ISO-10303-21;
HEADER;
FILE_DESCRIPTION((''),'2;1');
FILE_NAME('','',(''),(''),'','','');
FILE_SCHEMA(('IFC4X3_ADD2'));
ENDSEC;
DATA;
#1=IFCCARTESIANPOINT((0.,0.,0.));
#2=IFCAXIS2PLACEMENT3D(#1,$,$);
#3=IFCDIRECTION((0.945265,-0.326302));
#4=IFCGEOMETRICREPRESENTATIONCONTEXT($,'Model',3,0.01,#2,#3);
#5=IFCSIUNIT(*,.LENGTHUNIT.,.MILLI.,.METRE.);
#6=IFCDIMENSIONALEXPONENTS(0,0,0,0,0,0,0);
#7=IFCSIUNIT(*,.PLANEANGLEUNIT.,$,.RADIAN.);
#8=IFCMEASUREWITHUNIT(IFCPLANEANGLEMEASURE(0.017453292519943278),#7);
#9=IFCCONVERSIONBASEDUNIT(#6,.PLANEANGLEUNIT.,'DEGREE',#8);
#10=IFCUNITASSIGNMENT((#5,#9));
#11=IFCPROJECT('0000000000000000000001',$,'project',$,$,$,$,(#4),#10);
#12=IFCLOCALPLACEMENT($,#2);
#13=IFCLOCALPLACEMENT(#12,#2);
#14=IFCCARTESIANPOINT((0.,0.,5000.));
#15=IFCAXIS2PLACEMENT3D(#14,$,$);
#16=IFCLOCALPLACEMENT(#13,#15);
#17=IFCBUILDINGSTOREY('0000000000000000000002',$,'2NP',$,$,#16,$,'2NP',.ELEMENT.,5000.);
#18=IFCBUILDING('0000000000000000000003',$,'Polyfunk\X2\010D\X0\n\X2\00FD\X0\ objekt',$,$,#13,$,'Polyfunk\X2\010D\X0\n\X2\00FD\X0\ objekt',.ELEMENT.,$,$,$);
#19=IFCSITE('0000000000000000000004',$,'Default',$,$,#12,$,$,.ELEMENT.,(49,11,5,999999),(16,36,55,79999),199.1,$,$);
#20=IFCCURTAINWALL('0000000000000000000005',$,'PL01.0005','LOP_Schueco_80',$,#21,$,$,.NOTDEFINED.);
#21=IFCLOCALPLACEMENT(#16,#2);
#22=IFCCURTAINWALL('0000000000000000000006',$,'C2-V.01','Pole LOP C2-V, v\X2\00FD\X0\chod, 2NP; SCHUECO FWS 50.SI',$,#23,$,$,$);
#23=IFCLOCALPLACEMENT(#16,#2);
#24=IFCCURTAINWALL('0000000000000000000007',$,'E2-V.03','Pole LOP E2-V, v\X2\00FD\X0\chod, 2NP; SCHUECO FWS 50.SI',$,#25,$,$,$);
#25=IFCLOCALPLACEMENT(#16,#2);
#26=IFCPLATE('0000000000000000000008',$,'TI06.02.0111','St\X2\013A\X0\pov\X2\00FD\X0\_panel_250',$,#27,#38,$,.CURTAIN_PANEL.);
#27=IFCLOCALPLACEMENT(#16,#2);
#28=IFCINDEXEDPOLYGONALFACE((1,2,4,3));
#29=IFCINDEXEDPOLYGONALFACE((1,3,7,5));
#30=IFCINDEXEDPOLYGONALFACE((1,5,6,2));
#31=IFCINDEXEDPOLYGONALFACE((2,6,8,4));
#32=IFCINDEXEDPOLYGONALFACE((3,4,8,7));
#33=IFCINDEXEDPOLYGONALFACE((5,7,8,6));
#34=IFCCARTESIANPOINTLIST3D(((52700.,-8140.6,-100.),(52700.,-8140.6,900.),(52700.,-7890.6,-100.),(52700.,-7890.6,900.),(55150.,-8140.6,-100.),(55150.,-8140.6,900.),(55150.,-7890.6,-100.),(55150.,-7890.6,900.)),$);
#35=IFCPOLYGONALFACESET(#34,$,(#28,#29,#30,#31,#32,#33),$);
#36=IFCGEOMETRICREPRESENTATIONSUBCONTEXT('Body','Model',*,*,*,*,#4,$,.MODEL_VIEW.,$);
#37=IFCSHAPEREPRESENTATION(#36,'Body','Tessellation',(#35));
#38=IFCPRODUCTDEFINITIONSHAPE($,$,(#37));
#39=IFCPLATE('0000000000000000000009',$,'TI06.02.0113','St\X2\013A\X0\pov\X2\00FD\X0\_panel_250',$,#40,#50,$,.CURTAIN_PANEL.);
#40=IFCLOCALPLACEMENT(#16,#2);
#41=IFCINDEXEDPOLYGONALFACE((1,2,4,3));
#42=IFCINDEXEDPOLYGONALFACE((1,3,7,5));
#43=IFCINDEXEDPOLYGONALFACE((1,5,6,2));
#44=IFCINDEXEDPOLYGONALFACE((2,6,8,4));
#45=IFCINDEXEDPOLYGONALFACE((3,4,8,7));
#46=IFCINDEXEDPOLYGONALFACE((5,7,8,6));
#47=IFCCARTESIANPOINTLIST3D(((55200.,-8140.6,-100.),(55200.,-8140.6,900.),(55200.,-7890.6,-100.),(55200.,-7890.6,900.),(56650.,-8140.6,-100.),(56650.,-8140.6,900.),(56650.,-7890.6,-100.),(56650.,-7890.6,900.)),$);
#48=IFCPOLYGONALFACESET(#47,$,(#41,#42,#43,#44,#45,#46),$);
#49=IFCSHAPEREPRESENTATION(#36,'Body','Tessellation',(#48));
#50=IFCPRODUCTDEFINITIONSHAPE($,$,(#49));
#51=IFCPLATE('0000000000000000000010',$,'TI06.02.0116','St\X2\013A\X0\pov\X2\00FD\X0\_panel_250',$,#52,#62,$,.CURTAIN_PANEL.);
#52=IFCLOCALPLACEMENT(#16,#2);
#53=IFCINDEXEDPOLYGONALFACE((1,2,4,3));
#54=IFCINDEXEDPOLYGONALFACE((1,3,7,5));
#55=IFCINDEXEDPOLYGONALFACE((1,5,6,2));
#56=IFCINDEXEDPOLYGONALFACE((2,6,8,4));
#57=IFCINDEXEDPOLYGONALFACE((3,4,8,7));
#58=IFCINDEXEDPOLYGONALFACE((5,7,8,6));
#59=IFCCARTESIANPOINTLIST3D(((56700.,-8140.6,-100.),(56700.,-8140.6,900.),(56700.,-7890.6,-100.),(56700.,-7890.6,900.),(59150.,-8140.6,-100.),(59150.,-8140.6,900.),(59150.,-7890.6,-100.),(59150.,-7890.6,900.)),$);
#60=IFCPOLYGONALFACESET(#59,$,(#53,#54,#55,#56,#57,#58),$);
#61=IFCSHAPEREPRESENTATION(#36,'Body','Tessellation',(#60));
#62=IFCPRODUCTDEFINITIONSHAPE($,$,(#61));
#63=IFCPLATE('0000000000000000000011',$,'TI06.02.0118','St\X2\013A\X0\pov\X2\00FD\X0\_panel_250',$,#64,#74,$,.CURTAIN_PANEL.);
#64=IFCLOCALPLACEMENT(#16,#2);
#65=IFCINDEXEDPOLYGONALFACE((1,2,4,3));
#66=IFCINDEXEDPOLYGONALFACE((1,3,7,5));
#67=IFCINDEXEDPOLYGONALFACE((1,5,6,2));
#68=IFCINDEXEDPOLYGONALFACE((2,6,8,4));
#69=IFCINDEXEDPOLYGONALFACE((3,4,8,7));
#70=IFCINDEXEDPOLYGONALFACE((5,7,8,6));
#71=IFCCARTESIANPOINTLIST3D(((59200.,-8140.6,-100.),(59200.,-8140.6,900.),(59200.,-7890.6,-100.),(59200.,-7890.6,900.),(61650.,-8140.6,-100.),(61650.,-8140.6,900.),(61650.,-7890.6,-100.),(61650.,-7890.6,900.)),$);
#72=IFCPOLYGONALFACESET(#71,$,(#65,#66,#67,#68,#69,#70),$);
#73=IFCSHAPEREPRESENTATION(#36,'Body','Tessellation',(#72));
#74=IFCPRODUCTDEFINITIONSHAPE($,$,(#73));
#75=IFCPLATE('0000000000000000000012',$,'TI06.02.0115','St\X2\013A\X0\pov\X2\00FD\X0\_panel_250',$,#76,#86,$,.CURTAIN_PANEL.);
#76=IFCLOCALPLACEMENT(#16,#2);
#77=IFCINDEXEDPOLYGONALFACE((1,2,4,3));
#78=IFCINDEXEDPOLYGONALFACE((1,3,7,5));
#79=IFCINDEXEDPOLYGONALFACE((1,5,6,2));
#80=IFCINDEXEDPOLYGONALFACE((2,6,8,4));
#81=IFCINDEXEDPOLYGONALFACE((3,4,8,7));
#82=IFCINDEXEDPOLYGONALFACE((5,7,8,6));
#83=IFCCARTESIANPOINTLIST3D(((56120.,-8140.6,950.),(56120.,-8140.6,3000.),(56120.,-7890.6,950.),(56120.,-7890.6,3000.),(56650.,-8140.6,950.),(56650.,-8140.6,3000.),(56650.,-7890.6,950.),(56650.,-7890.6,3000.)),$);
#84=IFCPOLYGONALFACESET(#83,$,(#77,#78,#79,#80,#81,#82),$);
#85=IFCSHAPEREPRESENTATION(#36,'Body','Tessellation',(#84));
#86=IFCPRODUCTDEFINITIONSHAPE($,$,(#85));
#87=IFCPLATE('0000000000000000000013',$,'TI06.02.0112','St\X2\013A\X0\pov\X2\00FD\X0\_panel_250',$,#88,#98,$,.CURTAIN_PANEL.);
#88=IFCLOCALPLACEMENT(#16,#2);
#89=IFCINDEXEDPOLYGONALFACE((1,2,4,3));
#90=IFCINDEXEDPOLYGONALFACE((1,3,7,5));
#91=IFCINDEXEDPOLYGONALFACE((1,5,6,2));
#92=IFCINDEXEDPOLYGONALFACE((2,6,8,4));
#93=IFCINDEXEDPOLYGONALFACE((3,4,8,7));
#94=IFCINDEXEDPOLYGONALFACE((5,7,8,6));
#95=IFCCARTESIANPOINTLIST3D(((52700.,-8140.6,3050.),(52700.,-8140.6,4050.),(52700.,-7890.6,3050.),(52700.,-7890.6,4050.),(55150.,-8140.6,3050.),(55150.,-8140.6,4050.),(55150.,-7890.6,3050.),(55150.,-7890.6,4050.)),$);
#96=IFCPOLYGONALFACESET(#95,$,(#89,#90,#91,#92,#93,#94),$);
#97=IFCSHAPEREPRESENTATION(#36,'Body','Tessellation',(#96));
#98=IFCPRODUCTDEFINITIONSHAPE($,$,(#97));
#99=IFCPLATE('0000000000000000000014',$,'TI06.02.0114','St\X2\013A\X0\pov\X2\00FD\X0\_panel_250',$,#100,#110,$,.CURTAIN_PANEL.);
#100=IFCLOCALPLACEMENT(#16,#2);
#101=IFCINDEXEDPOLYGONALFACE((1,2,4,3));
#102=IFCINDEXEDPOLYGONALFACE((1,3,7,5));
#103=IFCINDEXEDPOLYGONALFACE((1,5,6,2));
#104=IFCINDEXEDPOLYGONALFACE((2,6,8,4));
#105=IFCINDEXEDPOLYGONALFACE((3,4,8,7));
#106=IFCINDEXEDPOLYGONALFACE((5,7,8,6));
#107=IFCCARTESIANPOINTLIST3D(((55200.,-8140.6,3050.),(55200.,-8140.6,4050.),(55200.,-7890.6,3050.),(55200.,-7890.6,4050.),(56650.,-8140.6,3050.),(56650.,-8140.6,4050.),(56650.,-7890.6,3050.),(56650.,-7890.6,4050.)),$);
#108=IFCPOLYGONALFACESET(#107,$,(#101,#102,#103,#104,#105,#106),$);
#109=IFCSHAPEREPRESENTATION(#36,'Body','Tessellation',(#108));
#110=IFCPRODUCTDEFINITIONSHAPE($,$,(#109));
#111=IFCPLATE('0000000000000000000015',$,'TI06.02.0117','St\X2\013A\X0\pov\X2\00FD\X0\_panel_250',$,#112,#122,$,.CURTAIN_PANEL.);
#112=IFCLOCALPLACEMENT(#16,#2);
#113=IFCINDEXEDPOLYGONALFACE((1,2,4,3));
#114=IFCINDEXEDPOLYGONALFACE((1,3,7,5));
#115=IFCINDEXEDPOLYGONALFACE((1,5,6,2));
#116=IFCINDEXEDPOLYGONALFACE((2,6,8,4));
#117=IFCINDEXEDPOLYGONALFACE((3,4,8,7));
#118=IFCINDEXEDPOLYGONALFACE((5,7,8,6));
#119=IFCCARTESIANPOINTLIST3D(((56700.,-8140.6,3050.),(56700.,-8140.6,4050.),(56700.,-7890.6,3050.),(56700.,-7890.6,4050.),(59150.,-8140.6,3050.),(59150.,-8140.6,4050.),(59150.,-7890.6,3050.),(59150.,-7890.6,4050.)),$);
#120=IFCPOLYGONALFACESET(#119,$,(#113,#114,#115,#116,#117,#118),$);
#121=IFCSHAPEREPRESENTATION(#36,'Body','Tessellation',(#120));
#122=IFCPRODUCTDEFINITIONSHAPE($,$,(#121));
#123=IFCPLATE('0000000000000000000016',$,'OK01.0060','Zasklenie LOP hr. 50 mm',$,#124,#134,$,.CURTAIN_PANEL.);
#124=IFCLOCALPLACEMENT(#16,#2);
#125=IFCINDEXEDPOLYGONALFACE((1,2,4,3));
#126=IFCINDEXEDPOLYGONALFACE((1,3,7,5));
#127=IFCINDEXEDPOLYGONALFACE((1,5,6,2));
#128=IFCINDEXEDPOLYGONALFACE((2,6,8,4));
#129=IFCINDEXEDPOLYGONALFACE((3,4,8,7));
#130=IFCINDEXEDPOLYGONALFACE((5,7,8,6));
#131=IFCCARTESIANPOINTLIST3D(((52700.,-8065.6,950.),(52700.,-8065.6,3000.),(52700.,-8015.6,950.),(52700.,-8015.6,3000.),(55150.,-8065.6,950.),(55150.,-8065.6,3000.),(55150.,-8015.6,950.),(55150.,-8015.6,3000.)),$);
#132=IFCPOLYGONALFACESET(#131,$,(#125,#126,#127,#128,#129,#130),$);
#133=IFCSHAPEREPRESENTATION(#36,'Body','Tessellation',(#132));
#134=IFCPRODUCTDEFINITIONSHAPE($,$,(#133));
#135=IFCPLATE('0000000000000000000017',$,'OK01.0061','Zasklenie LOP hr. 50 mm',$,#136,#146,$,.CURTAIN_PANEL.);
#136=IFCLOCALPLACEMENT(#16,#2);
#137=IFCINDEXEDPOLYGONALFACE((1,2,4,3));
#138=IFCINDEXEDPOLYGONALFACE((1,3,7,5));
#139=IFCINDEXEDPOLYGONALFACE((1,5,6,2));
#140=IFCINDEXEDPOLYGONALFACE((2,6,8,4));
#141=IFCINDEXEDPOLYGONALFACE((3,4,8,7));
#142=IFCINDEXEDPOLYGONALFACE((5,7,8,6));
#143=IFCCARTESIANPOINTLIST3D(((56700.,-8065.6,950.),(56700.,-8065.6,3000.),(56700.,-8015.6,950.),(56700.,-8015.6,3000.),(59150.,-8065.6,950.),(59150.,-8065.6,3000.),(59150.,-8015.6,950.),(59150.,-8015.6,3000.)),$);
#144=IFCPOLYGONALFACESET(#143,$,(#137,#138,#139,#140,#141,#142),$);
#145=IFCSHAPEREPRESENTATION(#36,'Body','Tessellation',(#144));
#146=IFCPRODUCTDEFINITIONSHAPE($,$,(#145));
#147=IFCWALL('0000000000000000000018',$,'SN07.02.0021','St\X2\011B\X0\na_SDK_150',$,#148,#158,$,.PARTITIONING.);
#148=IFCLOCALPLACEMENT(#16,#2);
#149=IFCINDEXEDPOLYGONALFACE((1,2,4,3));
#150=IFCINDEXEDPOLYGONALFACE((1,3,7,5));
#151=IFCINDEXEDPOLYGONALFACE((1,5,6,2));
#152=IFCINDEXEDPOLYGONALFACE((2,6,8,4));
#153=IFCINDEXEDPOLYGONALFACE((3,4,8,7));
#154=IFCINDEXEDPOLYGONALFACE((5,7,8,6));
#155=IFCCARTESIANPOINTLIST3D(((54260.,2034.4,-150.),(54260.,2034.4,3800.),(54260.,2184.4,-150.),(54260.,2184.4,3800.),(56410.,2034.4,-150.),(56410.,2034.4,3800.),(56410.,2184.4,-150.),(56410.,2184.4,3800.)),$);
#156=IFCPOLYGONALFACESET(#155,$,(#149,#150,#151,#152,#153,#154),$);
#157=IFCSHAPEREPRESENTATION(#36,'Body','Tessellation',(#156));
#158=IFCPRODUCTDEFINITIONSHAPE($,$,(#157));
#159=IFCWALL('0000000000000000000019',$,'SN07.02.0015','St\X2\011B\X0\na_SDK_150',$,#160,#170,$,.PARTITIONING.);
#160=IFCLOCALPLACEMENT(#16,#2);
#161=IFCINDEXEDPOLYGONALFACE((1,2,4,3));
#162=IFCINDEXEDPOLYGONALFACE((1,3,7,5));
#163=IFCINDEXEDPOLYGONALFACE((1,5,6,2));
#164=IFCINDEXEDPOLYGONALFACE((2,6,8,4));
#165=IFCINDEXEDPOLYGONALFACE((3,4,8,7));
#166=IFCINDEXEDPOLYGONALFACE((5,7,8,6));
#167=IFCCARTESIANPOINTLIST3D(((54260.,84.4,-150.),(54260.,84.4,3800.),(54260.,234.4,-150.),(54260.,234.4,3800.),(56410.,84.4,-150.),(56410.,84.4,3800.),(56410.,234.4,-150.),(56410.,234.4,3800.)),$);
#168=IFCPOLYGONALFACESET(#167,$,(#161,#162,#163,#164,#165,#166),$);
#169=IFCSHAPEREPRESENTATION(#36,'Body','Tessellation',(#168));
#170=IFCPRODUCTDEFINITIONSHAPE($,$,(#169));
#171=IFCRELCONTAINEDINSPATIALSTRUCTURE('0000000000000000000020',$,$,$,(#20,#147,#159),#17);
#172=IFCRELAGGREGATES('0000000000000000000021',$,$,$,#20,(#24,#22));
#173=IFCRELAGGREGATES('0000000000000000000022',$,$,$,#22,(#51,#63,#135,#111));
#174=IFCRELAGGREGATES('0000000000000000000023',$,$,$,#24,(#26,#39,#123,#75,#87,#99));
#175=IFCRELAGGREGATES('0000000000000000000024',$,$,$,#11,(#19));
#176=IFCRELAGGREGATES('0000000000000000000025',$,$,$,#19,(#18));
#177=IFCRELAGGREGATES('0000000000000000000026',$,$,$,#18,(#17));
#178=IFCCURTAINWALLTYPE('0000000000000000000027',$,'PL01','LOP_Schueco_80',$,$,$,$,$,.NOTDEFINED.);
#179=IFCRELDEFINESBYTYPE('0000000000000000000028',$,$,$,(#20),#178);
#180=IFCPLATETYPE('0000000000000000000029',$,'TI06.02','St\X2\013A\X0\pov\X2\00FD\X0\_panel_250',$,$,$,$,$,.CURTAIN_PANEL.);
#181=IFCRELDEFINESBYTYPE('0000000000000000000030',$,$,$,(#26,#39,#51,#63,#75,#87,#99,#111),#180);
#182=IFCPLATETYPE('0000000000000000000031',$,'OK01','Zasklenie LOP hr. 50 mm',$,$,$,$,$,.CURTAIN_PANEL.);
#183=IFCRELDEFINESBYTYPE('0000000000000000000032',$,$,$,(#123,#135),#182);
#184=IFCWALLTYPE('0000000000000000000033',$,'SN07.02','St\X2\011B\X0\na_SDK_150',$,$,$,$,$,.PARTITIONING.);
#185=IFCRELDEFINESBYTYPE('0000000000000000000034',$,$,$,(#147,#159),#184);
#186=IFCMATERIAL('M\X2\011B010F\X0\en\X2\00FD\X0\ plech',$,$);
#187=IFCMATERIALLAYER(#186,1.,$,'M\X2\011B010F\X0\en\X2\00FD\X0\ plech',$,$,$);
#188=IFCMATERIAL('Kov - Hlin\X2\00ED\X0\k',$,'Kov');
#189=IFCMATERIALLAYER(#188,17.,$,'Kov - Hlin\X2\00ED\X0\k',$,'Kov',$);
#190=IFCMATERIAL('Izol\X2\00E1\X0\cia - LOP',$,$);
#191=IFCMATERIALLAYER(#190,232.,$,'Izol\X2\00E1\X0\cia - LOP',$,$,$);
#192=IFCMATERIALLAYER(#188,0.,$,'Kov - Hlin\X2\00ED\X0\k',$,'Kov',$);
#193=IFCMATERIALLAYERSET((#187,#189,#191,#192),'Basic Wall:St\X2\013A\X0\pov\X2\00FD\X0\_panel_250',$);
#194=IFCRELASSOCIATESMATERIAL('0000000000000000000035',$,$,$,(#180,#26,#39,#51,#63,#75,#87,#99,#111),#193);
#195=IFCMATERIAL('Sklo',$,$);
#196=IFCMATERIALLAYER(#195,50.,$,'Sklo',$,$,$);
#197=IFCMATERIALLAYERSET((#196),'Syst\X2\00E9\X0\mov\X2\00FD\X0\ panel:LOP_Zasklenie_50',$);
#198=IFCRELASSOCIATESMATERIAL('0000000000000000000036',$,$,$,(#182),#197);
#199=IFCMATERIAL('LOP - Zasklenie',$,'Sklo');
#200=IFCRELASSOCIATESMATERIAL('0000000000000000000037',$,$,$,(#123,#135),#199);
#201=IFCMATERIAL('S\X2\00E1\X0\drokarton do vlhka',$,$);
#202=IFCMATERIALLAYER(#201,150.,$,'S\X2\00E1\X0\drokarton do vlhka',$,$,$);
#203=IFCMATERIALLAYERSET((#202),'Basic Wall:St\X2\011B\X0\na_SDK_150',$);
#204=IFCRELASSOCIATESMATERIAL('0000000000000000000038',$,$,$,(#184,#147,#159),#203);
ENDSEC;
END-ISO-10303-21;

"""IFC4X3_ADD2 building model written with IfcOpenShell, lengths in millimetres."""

from ifc_helpers import new_model, entity, si_unit, converted_unit, direction, frame, frame_2d, origin, origin_2d_with_axis, place, context, subcontext, project, spatial, polyline, rectangle, extrude, clip, bounded_halfspace, source, transform, mapped, material, layer, layer_set, layer_usage, type_object, type_shapes, element, aggregate, save


model = new_model("IFC4X3_ADD2")

# Units and contexts
model_context = context("Model", 3, precision=0.01, world=origin(), true_north=direction((0.945265, -0.326302)))
body_context = subcontext(model_context, "Body", "Model", "MODEL_VIEW")
ifc_project = project(units=[si_unit("LENGTHUNIT", "METRE", prefix="MILLI"), converted_unit("PLANEANGLEUNIT", "DEGREE", entity("IfcPlaneAngleMeasure", 0.017453292519943278), si_unit("PLANEANGLEUNIT", "RADIAN"), dimensions=[0, 0, 0, 0, 0, 0, 0])], contexts=[model_context])

# Site, building, storey
site_placement = place(None, origin())
site = spatial("IfcSite", under=ifc_project, at=site_placement, Name="Default", CompositionType="ELEMENT", RefLatitude=(49, 11, 5, 999999), RefLongitude=(16, 36, 55, 79999), RefElevation=199.1)
building_placement = place(site_placement, origin())
building = spatial("IfcBuilding", under=site, at=building_placement, Name="Polyfunkčný objekt", LongName="Polyfunkčný objekt", CompositionType="ELEMENT")
storey_placement = place(building_placement, frame((0.0, 0.0, 5000.0)))
storey = spatial("IfcBuildingStorey", under=building, at=storey_placement, Name="2NP", LongName="2NP", CompositionType="ELEMENT", Elevation=5000.0)

# Curtain walls, plates
curtain_wall_type = type_object("IfcCurtainWallType", Name="PL01", Description="LOP_Schueco_80", PredefinedType="NOTDEFINED")
curtain_wall_1_placement = place(storey_placement, frame((0.0, 0.0, -5000.0)))
curtain_wall_1 = element("IfcCurtainWall", 1, at=curtain_wall_1_placement, inside=storey, type_object=curtain_wall_type, Name="PL01.0005", Description="LOP_Schueco_80", PredefinedType="NOTDEFINED")
curtain_wall_2 = element("IfcCurtainWall", 2, Name="C2-V.01", Description="Pole LOP C2-V, východ, 2NP; SCHUECO FWS 50.SI")
curtain_wall_3 = element("IfcCurtainWall", 3, Name="E2-V.03", Description="Pole LOP E2-V, východ, 2NP; SCHUECO FWS 50.SI")
aggregate(curtain_wall_1, [curtain_wall_3, curtain_wall_2])
ifc_material_1 = material(Name="Měďený plech")
ifc_layer_1 = layer(ifc_material_1, 1.0, Name="Měďený plech")
ifc_material_2 = material(Name="Kov - Hliník", Category="Kov")
ifc_layer_2 = layer(ifc_material_2, 17.0, Name="Kov - Hliník", Category="Kov")
ifc_material_3 = material(Name="Izolácia - LOP")
ifc_layer_3 = layer(ifc_material_3, 232.0, Name="Izolácia - LOP")
ifc_layer_4 = layer(ifc_material_2, 0.0, Name="Kov - Hliník", Category="Kov")
ifc_layer_set_1 = layer_set([ifc_layer_1, ifc_layer_2, ifc_layer_3, ifc_layer_4], Name="Basic Wall:Stĺpový_panel_250")
ifc_layer_usage_1 = layer_usage(ifc_layer_set_1, "AXIS2", "POSITIVE", -125.0)
plate_type_1 = type_object("IfcPlateType", Name="TI06.02", Description="Stĺpový_panel_250", PredefinedType="CURTAIN_PANEL", material=ifc_layer_set_1)
plate_1_placement = place(storey_placement, frame((52700.0, -8015.6, -100.0)))
plate_1 = element("IfcPlate", 4, at=plate_1_placement, type_object=plate_type_1, material=ifc_layer_usage_1, Name="TI06.02.0111", Description="Stĺpový_panel_250", PredefinedType="CURTAIN_PANEL", context=body_context, shape_type="SweptSolid", body=[
    extrude(rectangle(XDim=250.0, YDim=2450.0, at=frame_2d((0.0, 0.0), x_axis=(1.0, 0.0))), frame((1225.0, 0.0, 0.0), z_axis=(0.0, 0.0, 1.0), x_axis=(0.0, 1.0, 0.0)), (0.0, 0.0, 1.0), 1000.0),
])
ifc_layer_usage_2 = layer_usage(ifc_layer_set_1, "AXIS2", "POSITIVE", -125.0)
plate_2_placement = place(storey_placement, frame((55200.0, -8015.6, -100.0)))
plate_2 = element("IfcPlate", 5, at=plate_2_placement, type_object=plate_type_1, material=ifc_layer_usage_2, Name="TI06.02.0113", Description="Stĺpový_panel_250", PredefinedType="CURTAIN_PANEL", context=body_context, shape_type="SweptSolid", body=[
    extrude(rectangle(XDim=250.0, YDim=1450.0, at=frame_2d((0.0, 0.0), x_axis=(1.0, 0.0))), frame((725.0, 0.0, 0.0), z_axis=(0.0, 0.0, 1.0), x_axis=(0.0, 1.0, 0.0)), (0.0, 0.0, 1.0), 1000.0),
])
ifc_layer_usage_3 = layer_usage(ifc_layer_set_1, "AXIS2", "POSITIVE", -125.0)
plate_3_placement = place(storey_placement, frame((56700.0, -8015.6, -100.0)))
plate_3 = element("IfcPlate", 6, at=plate_3_placement, type_object=plate_type_1, material=ifc_layer_usage_3, Name="TI06.02.0116", Description="Stĺpový_panel_250", PredefinedType="CURTAIN_PANEL", context=body_context, shape_type="SweptSolid", body=[
    extrude(rectangle(XDim=250.0, YDim=2450.0, at=frame_2d((0.0, 0.0), x_axis=(1.0, 0.0))), frame((1225.0, 0.0, 0.0), z_axis=(0.0, 0.0, 1.0), x_axis=(0.0, 1.0, 0.0)), (0.0, 0.0, 1.0), 1000.0),
])
ifc_layer_usage_4 = layer_usage(ifc_layer_set_1, "AXIS2", "POSITIVE", -125.0)
plate_4_placement = place(storey_placement, frame((59200.0, -8015.6, -100.0)))
plate_4 = element("IfcPlate", 7, at=plate_4_placement, type_object=plate_type_1, material=ifc_layer_usage_4, Name="TI06.02.0118", Description="Stĺpový_panel_250", PredefinedType="CURTAIN_PANEL", context=body_context, shape_type="SweptSolid", body=[
    extrude(rectangle(XDim=250.0, YDim=2450.0, at=frame_2d((0.0, 0.0), x_axis=(1.0, 0.0))), frame((1225.0, 0.0, 0.0), z_axis=(0.0, 0.0, 1.0), x_axis=(0.0, 1.0, 0.0)), (0.0, 0.0, 1.0), 1000.0),
])
ifc_layer_usage_5 = layer_usage(ifc_layer_set_1, "AXIS2", "POSITIVE", -125.0)
plate_5_placement = place(storey_placement, frame((56120.0, -8015.6, 950.0)))
plate_5 = element("IfcPlate", 8, at=plate_5_placement, type_object=plate_type_1, material=ifc_layer_usage_5, Name="TI06.02.0115", Description="Stĺpový_panel_250", PredefinedType="CURTAIN_PANEL", context=body_context, shape_type="SweptSolid", body=[
    extrude(rectangle(XDim=250.0, YDim=530.0, at=origin_2d_with_axis()), frame((265.0, 0.0, 0.0), z_axis=(0.0, 0.0, 1.0), x_axis=(0.0, 1.0, 0.0)), (0.0, 0.0, 1.0), 2050.0),
])
ifc_layer_usage_6 = layer_usage(ifc_layer_set_1, "AXIS2", "POSITIVE", -125.0)
plate_6_placement = place(storey_placement, frame((52700.0, -8015.6, 3050.0)))
plate_6 = element("IfcPlate", 9, at=plate_6_placement, type_object=plate_type_1, material=ifc_layer_usage_6, Name="TI06.02.0112", Description="Stĺpový_panel_250", PredefinedType="CURTAIN_PANEL", context=body_context, shape_type="SweptSolid", body=[
    extrude(rectangle(XDim=250.0, YDim=2450.0, at=frame_2d((0.0, 0.0), x_axis=(1.0, 0.0))), frame((1225.0, 0.0, 0.0), z_axis=(0.0, 0.0, 1.0), x_axis=(0.0, 1.0, 0.0)), (0.0, 0.0, 1.0), 1000.0),
])
ifc_layer_usage_7 = layer_usage(ifc_layer_set_1, "AXIS2", "POSITIVE", -125.0)
plate_7_placement = place(storey_placement, frame((55200.0, -8015.6, 3050.0)))
plate_7 = element("IfcPlate", 10, at=plate_7_placement, type_object=plate_type_1, material=ifc_layer_usage_7, Name="TI06.02.0114", Description="Stĺpový_panel_250", PredefinedType="CURTAIN_PANEL", context=body_context, shape_type="SweptSolid", body=[
    extrude(rectangle(XDim=250.0, YDim=1450.0, at=frame_2d((0.0, 0.0), x_axis=(1.0, 0.0))), frame((725.0, 0.0, 0.0), z_axis=(0.0, 0.0, 1.0), x_axis=(0.0, 1.0, 0.0)), (0.0, 0.0, 1.0), 1000.0),
])
ifc_layer_usage_8 = layer_usage(ifc_layer_set_1, "AXIS2", "POSITIVE", -125.0)
plate_8_placement = place(storey_placement, frame((56700.0, -8015.6, 3050.0)))
plate_8 = element("IfcPlate", 11, at=plate_8_placement, type_object=plate_type_1, material=ifc_layer_usage_8, Name="TI06.02.0117", Description="Stĺpový_panel_250", PredefinedType="CURTAIN_PANEL", context=body_context, shape_type="SweptSolid", body=[
    extrude(rectangle(XDim=250.0, YDim=2450.0, at=frame_2d((0.0, 0.0), x_axis=(1.0, 0.0))), frame((1225.0, 0.0, 0.0), z_axis=(0.0, 0.0, 1.0), x_axis=(0.0, 1.0, 0.0)), (0.0, 0.0, 1.0), 1000.0),
])
ifc_material_4 = material(Name="LOP - Zasklenie", Category="Sklo")
ifc_material_5 = material(Name="Sklo")
ifc_layer_5 = layer(ifc_material_5, 50.0, Name="Sklo")
ifc_layer_set_2 = layer_set([ifc_layer_5], Name="Systémový panel:LOP_Zasklenie_50")
plate_type_2 = type_object("IfcPlateType", Name="OK01", Description="Zasklenie LOP hr. 50 mm", PredefinedType="CURTAIN_PANEL", material=ifc_layer_set_2)
shared_shape_1 = source(origin(), body_context, "Body", "SweptSolid", [
    extrude(rectangle(XDim=50.0, YDim=2450.0, at=origin_2d_with_axis()), frame((0.0, -25.0, 0.0), z_axis=(0.0, 0.0, 1.0), x_axis=(0.0, 1.0, 0.0)), (0.0, 0.0, 1.0), 2050.0),
])
type_shapes(plate_type_2, [shared_shape_1])
plate_9_placement = place(curtain_wall_1_placement, frame((53925.0, -8015.6, 5950.0)))
plate_9 = element("IfcPlate", 12, at=plate_9_placement, type_object=plate_type_2, material=ifc_material_4, Name="OK01.0060", Description="Zasklenie LOP hr. 50 mm", PredefinedType="CURTAIN_PANEL", context=body_context, shape_type="MappedRepresentation", body=[
    mapped(shared_shape_1, transform((0.0, 0.0, 0.0), scale=1.0)),
])
plate_10_placement = place(curtain_wall_1_placement, frame((57925.0, -8015.6, 5950.0)))
plate_10 = element("IfcPlate", 13, at=plate_10_placement, type_object=plate_type_2, material=ifc_material_4, Name="OK01.0061", Description="Zasklenie LOP hr. 50 mm", PredefinedType="CURTAIN_PANEL", context=body_context, shape_type="MappedRepresentation", body=[
    mapped(shared_shape_1, transform((0.0, 0.0, 0.0), scale=1.0)),
])
aggregate(curtain_wall_2, [plate_3, plate_4, plate_10, plate_8])

# Walls
ifc_material_6 = material(Name="Sádrokarton do vlhka")
ifc_layer_6 = layer(ifc_material_6, 150.0, Name="Sádrokarton do vlhka")
ifc_layer_set_3 = layer_set([ifc_layer_6], Name="Basic Wall:Stěna_SDK_150")
wall_type_1 = type_object("IfcWallType", Name="SN07.02", Description="Stěna_SDK_150", PredefinedType="PARTITIONING", material=ifc_layer_set_3)
wall_1_placement = place(storey_placement, frame((56410.0, 2109.4, -150.0), z_axis=(0.0, 0.0, 1.0), x_axis=(-1.0, 0.0, 0.0)))
element("IfcWall", 14, at=wall_1_placement, inside=storey, type_object=wall_type_1, material=ifc_layer_set_3, Name="SN07.02.0021", Description="Stěna_SDK_150", PredefinedType="PARTITIONING", context=body_context, shape_type="Clipping", body=[
    clip(clip(extrude(rectangle(XDim=2150.0, YDim=150.0, at=frame_2d((1075.0, 0.0), x_axis=(-1.0, 0.0))), origin(), (0.0, 0.0, 1.0), 3950.0), bounded_halfspace(frame((2150.0, -75.0, 0.0)), True, frame((2150.0, -75.0, 0.0)), polyline([(0.0, 0.0), (0.0, 150.0), (-2150.0, 150.0), (-2150.0, 0.0), (0.0, 0.0)]))), bounded_halfspace(frame((0.0, -75.0, 3950.0), z_axis=(0.0, 0.0, -1.0), x_axis=(-1.0, 0.0, 0.0)), True, frame((0.0, -75.0, 3950.0)), polyline([(0.0, 0.0), (2150.0, 0.0), (2150.0, 150.0), (0.0, 150.0), (0.0, 0.0)]))),
])
wall_2_placement = place(storey_placement, frame((56410.0, 159.4, -150.0), z_axis=(0.0, 0.0, 1.0), x_axis=(-1.0, 0.0, 0.0)))
element("IfcWall", 15, at=wall_2_placement, inside=storey, type_object=wall_type_1, material=ifc_layer_set_3, Name="SN07.02.0015", Description="Stěna_SDK_150", PredefinedType="PARTITIONING", context=body_context, shape_type="Clipping", body=[
    clip(clip(extrude(rectangle(XDim=2150.0, YDim=150.0, at=frame_2d((1075.0, 0.0), x_axis=(-1.0, 0.0))), origin(), (0.0, 0.0, 1.0), 3950.0), bounded_halfspace(frame((2150.0, -75.0, 0.0)), True, frame((2150.0, -75.0, 0.0)), polyline([(0.0, 0.0), (0.0, 150.0), (-2150.0, 150.0), (-2150.0, 0.0), (0.0, 0.0)]))), bounded_halfspace(frame((0.0, -75.0, 3950.0), z_axis=(0.0, 0.0, -1.0), x_axis=(-1.0, 0.0, 0.0)), True, frame((0.0, -75.0, 3950.0)), polyline([(0.0, 0.0), (2150.0, 0.0), (2150.0, 150.0), (0.0, 150.0), (0.0, 0.0)]))),
])

aggregate(curtain_wall_3, [plate_1, plate_2, plate_9, plate_5, plate_6, plate_7])

save(model, "model.ifc")
